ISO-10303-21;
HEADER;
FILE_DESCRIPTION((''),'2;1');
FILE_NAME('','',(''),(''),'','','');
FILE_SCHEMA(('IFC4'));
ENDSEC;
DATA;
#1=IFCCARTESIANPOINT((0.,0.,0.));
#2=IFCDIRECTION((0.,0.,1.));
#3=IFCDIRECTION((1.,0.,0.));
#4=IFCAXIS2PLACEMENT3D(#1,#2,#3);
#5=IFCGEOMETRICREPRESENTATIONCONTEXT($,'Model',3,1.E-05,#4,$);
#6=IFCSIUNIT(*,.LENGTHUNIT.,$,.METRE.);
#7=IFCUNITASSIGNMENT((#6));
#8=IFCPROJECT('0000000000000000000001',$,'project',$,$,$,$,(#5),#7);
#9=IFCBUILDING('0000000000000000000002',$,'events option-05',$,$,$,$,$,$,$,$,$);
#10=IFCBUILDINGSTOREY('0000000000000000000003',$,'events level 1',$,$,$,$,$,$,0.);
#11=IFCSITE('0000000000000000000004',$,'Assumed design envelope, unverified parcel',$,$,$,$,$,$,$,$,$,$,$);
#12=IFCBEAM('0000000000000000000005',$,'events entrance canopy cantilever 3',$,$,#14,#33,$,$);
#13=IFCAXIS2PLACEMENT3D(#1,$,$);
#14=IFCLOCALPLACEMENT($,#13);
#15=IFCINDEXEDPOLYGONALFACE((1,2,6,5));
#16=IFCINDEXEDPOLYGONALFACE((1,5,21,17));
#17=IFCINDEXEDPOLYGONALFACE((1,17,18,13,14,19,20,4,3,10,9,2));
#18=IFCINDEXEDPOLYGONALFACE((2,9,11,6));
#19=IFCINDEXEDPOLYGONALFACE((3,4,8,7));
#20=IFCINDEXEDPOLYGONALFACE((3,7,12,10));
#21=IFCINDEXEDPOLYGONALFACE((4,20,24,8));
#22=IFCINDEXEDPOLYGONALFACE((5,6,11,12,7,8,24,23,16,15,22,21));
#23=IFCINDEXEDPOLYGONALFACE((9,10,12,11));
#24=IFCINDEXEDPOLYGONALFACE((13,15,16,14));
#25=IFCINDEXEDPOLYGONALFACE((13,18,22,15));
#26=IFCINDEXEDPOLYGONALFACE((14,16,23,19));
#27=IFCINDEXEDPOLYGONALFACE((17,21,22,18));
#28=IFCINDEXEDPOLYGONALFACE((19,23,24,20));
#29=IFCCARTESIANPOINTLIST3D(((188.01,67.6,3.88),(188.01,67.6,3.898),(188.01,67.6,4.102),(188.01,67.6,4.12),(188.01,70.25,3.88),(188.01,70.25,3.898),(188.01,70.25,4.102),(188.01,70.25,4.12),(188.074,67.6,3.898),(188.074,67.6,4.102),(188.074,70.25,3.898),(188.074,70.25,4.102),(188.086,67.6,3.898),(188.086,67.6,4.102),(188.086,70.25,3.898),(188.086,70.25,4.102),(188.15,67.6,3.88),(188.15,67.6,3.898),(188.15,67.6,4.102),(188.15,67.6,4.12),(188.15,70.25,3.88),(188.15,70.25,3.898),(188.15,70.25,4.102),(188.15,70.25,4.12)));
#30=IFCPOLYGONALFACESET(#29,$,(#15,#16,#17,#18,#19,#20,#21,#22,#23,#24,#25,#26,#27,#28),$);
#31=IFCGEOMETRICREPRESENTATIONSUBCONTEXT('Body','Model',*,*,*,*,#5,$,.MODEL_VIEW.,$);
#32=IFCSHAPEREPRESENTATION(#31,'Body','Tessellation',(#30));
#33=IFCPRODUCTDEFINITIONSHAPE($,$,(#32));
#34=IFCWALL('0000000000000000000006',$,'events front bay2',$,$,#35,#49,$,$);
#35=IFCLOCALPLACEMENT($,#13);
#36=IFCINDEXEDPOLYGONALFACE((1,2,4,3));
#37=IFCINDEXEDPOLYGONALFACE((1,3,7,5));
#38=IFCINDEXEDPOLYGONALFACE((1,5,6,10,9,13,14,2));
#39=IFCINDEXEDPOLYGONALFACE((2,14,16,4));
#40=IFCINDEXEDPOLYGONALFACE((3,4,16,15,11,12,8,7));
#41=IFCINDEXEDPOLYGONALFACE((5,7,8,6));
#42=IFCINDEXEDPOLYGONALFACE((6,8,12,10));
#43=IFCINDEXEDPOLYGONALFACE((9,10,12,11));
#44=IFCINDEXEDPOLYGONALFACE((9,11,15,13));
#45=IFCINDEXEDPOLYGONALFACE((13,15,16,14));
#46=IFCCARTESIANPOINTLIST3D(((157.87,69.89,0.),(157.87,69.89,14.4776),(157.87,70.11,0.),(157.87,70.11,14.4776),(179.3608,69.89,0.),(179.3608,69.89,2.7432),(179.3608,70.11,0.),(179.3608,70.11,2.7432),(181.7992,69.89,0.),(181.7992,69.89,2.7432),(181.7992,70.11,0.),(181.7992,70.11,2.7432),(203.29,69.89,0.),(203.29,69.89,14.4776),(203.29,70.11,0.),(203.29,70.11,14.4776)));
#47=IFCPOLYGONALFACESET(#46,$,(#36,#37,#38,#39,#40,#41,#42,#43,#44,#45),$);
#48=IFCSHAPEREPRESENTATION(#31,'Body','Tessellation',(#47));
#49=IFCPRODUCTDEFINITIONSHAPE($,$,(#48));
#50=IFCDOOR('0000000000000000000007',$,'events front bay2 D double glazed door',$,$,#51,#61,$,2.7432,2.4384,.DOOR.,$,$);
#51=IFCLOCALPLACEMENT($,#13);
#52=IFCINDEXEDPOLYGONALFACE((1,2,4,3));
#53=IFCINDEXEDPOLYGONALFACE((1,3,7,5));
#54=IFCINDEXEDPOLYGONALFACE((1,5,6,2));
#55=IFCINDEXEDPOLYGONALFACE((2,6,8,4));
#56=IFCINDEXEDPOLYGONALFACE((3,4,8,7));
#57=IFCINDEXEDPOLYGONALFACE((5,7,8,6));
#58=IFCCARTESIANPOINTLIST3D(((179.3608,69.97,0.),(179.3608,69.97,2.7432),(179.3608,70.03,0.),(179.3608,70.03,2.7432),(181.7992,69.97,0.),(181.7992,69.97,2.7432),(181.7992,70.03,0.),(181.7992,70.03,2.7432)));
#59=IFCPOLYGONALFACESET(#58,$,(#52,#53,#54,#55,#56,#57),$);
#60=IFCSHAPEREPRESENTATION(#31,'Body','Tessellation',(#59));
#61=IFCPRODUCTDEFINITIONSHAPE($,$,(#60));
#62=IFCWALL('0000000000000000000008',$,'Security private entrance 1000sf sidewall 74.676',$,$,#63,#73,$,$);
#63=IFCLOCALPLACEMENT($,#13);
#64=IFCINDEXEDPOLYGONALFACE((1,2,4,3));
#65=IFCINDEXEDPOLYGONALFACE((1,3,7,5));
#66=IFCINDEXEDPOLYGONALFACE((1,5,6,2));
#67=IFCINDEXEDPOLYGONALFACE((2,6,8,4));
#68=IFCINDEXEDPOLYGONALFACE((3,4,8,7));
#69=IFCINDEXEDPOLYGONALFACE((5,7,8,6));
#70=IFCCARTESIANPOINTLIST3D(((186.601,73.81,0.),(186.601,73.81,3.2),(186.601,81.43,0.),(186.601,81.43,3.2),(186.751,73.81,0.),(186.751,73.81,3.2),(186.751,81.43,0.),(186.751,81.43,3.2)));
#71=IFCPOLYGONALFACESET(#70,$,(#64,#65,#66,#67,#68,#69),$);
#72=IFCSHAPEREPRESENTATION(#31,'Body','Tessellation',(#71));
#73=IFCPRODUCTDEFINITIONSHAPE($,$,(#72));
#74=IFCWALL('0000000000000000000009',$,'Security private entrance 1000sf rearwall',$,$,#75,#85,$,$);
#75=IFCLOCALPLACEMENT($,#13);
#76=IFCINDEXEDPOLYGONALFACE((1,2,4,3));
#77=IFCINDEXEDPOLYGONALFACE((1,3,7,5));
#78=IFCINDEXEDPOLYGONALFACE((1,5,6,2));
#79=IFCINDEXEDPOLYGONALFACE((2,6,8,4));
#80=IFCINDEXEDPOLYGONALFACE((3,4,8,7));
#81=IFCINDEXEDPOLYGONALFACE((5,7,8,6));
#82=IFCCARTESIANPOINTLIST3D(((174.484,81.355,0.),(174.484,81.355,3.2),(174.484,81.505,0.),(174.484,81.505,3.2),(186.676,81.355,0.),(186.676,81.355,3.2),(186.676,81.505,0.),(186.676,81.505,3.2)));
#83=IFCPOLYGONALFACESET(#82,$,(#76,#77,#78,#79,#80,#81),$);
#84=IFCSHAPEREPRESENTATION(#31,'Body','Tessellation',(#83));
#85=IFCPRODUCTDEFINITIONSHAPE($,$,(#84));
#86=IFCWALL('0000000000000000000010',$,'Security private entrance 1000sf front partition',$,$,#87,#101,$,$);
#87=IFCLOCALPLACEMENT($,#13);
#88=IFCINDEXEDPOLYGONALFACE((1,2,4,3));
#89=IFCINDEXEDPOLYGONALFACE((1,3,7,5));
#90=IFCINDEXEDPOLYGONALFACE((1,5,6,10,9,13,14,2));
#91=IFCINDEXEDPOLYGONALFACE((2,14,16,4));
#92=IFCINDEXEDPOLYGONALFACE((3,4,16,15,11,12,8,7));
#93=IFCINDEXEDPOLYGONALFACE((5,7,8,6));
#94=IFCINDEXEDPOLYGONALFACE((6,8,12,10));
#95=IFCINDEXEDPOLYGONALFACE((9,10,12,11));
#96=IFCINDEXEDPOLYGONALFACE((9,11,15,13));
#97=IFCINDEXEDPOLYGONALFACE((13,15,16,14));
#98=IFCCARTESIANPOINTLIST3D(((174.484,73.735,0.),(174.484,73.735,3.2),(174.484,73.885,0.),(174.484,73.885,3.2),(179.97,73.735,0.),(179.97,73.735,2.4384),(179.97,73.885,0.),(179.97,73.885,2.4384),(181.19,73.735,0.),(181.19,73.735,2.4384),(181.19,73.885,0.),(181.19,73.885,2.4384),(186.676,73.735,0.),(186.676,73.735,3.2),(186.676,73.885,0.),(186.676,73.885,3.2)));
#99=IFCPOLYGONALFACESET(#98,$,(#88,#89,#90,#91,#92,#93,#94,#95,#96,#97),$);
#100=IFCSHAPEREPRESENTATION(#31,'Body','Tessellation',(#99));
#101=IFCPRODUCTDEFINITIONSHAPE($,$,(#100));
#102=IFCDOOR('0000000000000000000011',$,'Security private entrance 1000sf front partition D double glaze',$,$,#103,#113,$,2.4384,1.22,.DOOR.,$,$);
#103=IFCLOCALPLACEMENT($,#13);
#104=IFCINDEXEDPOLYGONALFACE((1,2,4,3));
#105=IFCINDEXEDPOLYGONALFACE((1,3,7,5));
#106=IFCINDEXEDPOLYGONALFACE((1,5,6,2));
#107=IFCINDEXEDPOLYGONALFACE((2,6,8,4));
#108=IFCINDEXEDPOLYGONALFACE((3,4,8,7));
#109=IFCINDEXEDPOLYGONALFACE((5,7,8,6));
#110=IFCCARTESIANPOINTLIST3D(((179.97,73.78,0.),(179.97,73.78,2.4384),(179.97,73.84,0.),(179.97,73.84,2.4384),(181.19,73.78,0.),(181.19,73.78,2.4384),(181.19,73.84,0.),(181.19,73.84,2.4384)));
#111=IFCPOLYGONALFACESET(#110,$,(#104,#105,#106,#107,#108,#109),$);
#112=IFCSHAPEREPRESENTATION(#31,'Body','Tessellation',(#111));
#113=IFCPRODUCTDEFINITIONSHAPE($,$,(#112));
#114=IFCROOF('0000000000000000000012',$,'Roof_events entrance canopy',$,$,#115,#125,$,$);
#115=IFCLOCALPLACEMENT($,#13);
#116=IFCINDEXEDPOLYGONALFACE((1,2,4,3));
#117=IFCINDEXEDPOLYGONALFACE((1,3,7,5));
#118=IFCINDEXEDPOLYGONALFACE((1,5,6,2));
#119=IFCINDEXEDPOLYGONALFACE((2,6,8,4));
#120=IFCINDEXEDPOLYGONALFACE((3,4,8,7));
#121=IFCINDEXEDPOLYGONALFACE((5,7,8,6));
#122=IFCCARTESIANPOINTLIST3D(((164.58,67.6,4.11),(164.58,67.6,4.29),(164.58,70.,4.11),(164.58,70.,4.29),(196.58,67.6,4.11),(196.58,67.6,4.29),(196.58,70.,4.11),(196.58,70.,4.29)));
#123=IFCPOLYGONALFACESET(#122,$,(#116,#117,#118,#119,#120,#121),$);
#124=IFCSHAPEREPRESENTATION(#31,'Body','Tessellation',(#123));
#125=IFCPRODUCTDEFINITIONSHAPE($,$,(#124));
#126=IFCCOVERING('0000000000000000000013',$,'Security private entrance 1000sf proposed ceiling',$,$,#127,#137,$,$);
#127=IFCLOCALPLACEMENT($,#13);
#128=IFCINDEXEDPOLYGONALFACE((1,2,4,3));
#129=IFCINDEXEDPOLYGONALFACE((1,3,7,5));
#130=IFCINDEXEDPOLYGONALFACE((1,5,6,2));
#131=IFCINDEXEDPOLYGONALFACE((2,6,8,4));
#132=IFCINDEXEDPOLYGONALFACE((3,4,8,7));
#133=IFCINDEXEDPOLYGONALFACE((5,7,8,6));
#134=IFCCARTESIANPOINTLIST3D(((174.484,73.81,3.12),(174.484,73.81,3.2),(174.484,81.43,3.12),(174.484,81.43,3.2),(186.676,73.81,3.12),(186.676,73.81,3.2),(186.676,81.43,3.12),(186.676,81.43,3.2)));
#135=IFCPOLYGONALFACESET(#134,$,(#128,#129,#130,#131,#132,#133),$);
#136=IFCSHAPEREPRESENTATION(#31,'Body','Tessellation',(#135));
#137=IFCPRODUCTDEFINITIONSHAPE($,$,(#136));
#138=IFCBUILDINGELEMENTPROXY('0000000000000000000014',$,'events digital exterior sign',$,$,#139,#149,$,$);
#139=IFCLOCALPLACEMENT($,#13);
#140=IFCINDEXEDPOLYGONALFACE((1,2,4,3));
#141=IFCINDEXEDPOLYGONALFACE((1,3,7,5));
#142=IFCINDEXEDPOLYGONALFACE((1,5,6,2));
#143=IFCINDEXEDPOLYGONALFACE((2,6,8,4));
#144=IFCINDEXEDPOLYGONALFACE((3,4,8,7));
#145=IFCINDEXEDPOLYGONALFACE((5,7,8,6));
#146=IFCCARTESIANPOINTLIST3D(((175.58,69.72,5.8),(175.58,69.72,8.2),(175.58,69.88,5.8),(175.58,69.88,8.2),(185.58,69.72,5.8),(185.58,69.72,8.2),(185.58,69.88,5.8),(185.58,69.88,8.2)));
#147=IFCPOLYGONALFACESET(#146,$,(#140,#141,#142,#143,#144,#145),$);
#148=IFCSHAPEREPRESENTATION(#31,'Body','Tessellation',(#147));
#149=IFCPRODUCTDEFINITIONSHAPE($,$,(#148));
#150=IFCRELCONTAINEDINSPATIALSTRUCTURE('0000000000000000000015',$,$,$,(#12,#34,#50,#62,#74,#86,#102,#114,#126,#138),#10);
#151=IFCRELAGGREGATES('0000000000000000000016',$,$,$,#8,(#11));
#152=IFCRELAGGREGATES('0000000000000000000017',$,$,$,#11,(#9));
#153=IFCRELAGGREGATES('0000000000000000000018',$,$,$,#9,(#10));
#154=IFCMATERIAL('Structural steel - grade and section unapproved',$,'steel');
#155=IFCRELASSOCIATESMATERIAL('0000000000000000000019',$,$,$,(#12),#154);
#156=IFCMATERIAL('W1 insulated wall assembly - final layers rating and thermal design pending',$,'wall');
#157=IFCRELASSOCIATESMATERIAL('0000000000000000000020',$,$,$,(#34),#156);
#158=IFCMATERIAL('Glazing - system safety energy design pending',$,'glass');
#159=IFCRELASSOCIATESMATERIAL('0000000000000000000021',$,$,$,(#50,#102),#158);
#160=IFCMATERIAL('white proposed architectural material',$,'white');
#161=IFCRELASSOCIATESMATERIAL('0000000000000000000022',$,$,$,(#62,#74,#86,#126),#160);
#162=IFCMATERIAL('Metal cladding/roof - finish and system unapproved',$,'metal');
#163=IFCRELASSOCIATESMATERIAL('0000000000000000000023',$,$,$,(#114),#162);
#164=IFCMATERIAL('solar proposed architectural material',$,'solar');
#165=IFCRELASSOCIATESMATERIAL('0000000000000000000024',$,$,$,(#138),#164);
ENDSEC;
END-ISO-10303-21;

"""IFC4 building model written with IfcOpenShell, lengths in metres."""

from ifc_helpers import new_model, si_unit, frame, origin_with_axes, place, context, subcontext, project, spatial, rectangle, i_section, extrude, material, element, fill, save


model = new_model("IFC4")

# Units and contexts
model_context = context("Model", 3, precision=1e-05, world=origin_with_axes())
body_context = subcontext(model_context, "Body", "Model", "MODEL_VIEW")
ifc_project = project(units=[si_unit("LENGTHUNIT", "METRE")], contexts=[model_context])

# Site, building, storey
site = spatial("IfcSite", under=ifc_project, Name="Assumed design envelope, unverified parcel")
building = spatial("IfcBuilding", under=site, Name="events option-05")
storey = spatial("IfcBuildingStorey", under=building, Name="events level 1", Elevation=0.0)

# Beam
ifc_material_1 = material(Name="Structural steel - grade and section unapproved", Category="steel")
for number, where, z_axis, x_axis, name in (
    (1, (188.08, 70.25, 4.0), (0.0, -1.0, 0.0), (1.0, 0.0, 0.0), "events entrance canopy cantilever 3"),
):
    element("IfcBeam", number, at=place(None, frame(where, z_axis=z_axis, x_axis=x_axis)), inside=storey, material=ifc_material_1, Name=name, context=body_context, shape_type="SweptSolid", body=[
        extrude(i_section(OverallWidth=0.14, OverallDepth=0.24, WebThickness=0.012, FlangeThickness=0.018, FilletRadius=0.0), origin_with_axes(), (0.0, 0.0, 1.0), 2.65),
    ])

# Wall, opening, door
ifc_material_2 = material(Name="W1 insulated wall assembly - final layers rating and thermal design pending", Category="wall")
wall_1_placement = place(None, frame((180.58, 70.0, 0.0), z_axis=(0.0, 0.0, 1.0), x_axis=(1.0, 0.0, 0.0)))
wall_1 = element("IfcWall", 2, at=wall_1_placement, inside=storey, material=ifc_material_2, Name="events front bay2", context=body_context, shape_type="SweptSolid", body=[
    extrude(rectangle(XDim=45.42, YDim=0.22), origin_with_axes(), (0.0, 0.0, 1.0), 14.4776),
])
opening_1_placement = place(None, frame((180.58, 70.0, 0.0), z_axis=(0.0, 0.0, 1.0), x_axis=(1.0, 0.0, 0.0)))
opening_1 = element("IfcOpeningElement", 3, at=opening_1_placement, cuts=wall_1, context=body_context, shape_type="SweptSolid", body=[
    extrude(rectangle(XDim=2.4384, YDim=0.32), origin_with_axes(), (0.0, 0.0, 1.0), 2.7432),
])
ifc_material_3 = material(Name="Glazing - system safety energy design pending", Category="glass")
door_1_placement = place(None, frame((180.58, 70.0, 0.0), z_axis=(0.0, 0.0, 1.0), x_axis=(1.0, 0.0, 0.0)))
door_1 = element("IfcDoor", 4, at=door_1_placement, inside=storey, material=ifc_material_3, Name="events front bay2 D double glazed door", OverallHeight=2.7432, OverallWidth=2.4384, PredefinedType="DOOR", context=body_context, shape_type="SweptSolid", body=[
    extrude(rectangle(XDim=2.4384, YDim=0.06), origin_with_axes(), (0.0, 0.0, 1.0), 2.7432),
])
fill(opening_1, door_1)

# Walls
ifc_material_4 = material(Name="white proposed architectural material", Category="white")
wall_2_placement = place(None, frame((186.676, 77.62, 0.0), z_axis=(0.0, 0.0, 1.0), x_axis=(1.0, 0.0, 0.0)))
element("IfcWall", 5, at=wall_2_placement, inside=storey, material=ifc_material_4, Name="Security private entrance 1000sf sidewall 74.676", context=body_context, shape_type="SweptSolid", body=[
    extrude(rectangle(XDim=0.15, YDim=7.62), origin_with_axes(), (0.0, 0.0, 1.0), 3.2),
])
wall_3_placement = place(None, frame((180.58, 81.43, 0.0), z_axis=(0.0, 0.0, 1.0), x_axis=(1.0, 0.0, 0.0)))
element("IfcWall", 6, at=wall_3_placement, inside=storey, material=ifc_material_4, Name="Security private entrance 1000sf rearwall", context=body_context, shape_type="SweptSolid", body=[
    extrude(rectangle(XDim=12.192, YDim=0.15), origin_with_axes(), (0.0, 0.0, 1.0), 3.2),
])

# Wall, opening, door
wall_4_placement = place(None, frame((180.58, 73.81, 0.0), z_axis=(0.0, 0.0, 1.0), x_axis=(1.0, 0.0, 0.0)))
wall_4 = element("IfcWall", 7, at=wall_4_placement, inside=storey, material=ifc_material_4, Name="Security private entrance 1000sf front partition", context=body_context, shape_type="SweptSolid", body=[
    extrude(rectangle(XDim=12.192, YDim=0.15), origin_with_axes(), (0.0, 0.0, 1.0), 3.2),
])
opening_2_placement = place(None, frame((180.58, 73.81, 0.0), z_axis=(0.0, 0.0, 1.0), x_axis=(1.0, 0.0, 0.0)))
opening_2 = element("IfcOpeningElement", 8, at=opening_2_placement, cuts=wall_4, context=body_context, shape_type="SweptSolid", body=[
    extrude(rectangle(XDim=1.22, YDim=0.25), origin_with_axes(), (0.0, 0.0, 1.0), 2.4384),
])
door_2_placement = place(None, frame((180.58, 73.81, 0.0), z_axis=(0.0, 0.0, 1.0), x_axis=(1.0, 0.0, 0.0)))
door_2 = element("IfcDoor", 9, at=door_2_placement, inside=storey, material=ifc_material_3, Name="Security private entrance 1000sf front partition D double glaze", OverallHeight=2.4384, OverallWidth=1.22, PredefinedType="DOOR", context=body_context, shape_type="SweptSolid", body=[
    extrude(rectangle(XDim=1.22, YDim=0.06), origin_with_axes(), (0.0, 0.0, 1.0), 2.4384),
])
fill(opening_2, door_2)

# Roof
ifc_material_5 = material(Name="Metal cladding/roof - finish and system unapproved", Category="metal")
roof_placement = place(None, frame((180.58, 68.8, 4.11), z_axis=(0.0, 0.0, 1.0), x_axis=(1.0, 0.0, 0.0)))
element("IfcRoof", 10, at=roof_placement, inside=storey, material=ifc_material_5, Name="Roof_events entrance canopy", context=body_context, shape_type="SweptSolid", body=[
    extrude(rectangle(XDim=32.0, YDim=2.4), origin_with_axes(), (0.0, 0.0, 1.0), 0.18),
])

# Covering
covering_placement = place(None, frame((180.58, 77.62, 3.12), z_axis=(0.0, 0.0, 1.0), x_axis=(1.0, 0.0, 0.0)))
element("IfcCovering", 11, at=covering_placement, inside=storey, material=ifc_material_4, Name="Security private entrance 1000sf proposed ceiling", context=body_context, shape_type="SweptSolid", body=[
    extrude(rectangle(XDim=12.192, YDim=7.62), origin_with_axes(), (0.0, 0.0, 1.0), 0.08),
])

# Building element proxy
ifc_material_6 = material(Name="solar proposed architectural material", Category="solar")
proxy_placement = place(None, frame((180.58, 69.8, 5.8), z_axis=(0.0, 0.0, 1.0), x_axis=(1.0, 0.0, 0.0)))
element("IfcBuildingElementProxy", 12, at=proxy_placement, inside=storey, material=ifc_material_6, Name="events digital exterior sign", context=body_context, shape_type="SweptSolid", body=[
    extrude(rectangle(XDim=10.0, YDim=0.16), origin_with_axes(), (0.0, 0.0, 1.0), 2.4),
])

save(model, "model.ifc")
